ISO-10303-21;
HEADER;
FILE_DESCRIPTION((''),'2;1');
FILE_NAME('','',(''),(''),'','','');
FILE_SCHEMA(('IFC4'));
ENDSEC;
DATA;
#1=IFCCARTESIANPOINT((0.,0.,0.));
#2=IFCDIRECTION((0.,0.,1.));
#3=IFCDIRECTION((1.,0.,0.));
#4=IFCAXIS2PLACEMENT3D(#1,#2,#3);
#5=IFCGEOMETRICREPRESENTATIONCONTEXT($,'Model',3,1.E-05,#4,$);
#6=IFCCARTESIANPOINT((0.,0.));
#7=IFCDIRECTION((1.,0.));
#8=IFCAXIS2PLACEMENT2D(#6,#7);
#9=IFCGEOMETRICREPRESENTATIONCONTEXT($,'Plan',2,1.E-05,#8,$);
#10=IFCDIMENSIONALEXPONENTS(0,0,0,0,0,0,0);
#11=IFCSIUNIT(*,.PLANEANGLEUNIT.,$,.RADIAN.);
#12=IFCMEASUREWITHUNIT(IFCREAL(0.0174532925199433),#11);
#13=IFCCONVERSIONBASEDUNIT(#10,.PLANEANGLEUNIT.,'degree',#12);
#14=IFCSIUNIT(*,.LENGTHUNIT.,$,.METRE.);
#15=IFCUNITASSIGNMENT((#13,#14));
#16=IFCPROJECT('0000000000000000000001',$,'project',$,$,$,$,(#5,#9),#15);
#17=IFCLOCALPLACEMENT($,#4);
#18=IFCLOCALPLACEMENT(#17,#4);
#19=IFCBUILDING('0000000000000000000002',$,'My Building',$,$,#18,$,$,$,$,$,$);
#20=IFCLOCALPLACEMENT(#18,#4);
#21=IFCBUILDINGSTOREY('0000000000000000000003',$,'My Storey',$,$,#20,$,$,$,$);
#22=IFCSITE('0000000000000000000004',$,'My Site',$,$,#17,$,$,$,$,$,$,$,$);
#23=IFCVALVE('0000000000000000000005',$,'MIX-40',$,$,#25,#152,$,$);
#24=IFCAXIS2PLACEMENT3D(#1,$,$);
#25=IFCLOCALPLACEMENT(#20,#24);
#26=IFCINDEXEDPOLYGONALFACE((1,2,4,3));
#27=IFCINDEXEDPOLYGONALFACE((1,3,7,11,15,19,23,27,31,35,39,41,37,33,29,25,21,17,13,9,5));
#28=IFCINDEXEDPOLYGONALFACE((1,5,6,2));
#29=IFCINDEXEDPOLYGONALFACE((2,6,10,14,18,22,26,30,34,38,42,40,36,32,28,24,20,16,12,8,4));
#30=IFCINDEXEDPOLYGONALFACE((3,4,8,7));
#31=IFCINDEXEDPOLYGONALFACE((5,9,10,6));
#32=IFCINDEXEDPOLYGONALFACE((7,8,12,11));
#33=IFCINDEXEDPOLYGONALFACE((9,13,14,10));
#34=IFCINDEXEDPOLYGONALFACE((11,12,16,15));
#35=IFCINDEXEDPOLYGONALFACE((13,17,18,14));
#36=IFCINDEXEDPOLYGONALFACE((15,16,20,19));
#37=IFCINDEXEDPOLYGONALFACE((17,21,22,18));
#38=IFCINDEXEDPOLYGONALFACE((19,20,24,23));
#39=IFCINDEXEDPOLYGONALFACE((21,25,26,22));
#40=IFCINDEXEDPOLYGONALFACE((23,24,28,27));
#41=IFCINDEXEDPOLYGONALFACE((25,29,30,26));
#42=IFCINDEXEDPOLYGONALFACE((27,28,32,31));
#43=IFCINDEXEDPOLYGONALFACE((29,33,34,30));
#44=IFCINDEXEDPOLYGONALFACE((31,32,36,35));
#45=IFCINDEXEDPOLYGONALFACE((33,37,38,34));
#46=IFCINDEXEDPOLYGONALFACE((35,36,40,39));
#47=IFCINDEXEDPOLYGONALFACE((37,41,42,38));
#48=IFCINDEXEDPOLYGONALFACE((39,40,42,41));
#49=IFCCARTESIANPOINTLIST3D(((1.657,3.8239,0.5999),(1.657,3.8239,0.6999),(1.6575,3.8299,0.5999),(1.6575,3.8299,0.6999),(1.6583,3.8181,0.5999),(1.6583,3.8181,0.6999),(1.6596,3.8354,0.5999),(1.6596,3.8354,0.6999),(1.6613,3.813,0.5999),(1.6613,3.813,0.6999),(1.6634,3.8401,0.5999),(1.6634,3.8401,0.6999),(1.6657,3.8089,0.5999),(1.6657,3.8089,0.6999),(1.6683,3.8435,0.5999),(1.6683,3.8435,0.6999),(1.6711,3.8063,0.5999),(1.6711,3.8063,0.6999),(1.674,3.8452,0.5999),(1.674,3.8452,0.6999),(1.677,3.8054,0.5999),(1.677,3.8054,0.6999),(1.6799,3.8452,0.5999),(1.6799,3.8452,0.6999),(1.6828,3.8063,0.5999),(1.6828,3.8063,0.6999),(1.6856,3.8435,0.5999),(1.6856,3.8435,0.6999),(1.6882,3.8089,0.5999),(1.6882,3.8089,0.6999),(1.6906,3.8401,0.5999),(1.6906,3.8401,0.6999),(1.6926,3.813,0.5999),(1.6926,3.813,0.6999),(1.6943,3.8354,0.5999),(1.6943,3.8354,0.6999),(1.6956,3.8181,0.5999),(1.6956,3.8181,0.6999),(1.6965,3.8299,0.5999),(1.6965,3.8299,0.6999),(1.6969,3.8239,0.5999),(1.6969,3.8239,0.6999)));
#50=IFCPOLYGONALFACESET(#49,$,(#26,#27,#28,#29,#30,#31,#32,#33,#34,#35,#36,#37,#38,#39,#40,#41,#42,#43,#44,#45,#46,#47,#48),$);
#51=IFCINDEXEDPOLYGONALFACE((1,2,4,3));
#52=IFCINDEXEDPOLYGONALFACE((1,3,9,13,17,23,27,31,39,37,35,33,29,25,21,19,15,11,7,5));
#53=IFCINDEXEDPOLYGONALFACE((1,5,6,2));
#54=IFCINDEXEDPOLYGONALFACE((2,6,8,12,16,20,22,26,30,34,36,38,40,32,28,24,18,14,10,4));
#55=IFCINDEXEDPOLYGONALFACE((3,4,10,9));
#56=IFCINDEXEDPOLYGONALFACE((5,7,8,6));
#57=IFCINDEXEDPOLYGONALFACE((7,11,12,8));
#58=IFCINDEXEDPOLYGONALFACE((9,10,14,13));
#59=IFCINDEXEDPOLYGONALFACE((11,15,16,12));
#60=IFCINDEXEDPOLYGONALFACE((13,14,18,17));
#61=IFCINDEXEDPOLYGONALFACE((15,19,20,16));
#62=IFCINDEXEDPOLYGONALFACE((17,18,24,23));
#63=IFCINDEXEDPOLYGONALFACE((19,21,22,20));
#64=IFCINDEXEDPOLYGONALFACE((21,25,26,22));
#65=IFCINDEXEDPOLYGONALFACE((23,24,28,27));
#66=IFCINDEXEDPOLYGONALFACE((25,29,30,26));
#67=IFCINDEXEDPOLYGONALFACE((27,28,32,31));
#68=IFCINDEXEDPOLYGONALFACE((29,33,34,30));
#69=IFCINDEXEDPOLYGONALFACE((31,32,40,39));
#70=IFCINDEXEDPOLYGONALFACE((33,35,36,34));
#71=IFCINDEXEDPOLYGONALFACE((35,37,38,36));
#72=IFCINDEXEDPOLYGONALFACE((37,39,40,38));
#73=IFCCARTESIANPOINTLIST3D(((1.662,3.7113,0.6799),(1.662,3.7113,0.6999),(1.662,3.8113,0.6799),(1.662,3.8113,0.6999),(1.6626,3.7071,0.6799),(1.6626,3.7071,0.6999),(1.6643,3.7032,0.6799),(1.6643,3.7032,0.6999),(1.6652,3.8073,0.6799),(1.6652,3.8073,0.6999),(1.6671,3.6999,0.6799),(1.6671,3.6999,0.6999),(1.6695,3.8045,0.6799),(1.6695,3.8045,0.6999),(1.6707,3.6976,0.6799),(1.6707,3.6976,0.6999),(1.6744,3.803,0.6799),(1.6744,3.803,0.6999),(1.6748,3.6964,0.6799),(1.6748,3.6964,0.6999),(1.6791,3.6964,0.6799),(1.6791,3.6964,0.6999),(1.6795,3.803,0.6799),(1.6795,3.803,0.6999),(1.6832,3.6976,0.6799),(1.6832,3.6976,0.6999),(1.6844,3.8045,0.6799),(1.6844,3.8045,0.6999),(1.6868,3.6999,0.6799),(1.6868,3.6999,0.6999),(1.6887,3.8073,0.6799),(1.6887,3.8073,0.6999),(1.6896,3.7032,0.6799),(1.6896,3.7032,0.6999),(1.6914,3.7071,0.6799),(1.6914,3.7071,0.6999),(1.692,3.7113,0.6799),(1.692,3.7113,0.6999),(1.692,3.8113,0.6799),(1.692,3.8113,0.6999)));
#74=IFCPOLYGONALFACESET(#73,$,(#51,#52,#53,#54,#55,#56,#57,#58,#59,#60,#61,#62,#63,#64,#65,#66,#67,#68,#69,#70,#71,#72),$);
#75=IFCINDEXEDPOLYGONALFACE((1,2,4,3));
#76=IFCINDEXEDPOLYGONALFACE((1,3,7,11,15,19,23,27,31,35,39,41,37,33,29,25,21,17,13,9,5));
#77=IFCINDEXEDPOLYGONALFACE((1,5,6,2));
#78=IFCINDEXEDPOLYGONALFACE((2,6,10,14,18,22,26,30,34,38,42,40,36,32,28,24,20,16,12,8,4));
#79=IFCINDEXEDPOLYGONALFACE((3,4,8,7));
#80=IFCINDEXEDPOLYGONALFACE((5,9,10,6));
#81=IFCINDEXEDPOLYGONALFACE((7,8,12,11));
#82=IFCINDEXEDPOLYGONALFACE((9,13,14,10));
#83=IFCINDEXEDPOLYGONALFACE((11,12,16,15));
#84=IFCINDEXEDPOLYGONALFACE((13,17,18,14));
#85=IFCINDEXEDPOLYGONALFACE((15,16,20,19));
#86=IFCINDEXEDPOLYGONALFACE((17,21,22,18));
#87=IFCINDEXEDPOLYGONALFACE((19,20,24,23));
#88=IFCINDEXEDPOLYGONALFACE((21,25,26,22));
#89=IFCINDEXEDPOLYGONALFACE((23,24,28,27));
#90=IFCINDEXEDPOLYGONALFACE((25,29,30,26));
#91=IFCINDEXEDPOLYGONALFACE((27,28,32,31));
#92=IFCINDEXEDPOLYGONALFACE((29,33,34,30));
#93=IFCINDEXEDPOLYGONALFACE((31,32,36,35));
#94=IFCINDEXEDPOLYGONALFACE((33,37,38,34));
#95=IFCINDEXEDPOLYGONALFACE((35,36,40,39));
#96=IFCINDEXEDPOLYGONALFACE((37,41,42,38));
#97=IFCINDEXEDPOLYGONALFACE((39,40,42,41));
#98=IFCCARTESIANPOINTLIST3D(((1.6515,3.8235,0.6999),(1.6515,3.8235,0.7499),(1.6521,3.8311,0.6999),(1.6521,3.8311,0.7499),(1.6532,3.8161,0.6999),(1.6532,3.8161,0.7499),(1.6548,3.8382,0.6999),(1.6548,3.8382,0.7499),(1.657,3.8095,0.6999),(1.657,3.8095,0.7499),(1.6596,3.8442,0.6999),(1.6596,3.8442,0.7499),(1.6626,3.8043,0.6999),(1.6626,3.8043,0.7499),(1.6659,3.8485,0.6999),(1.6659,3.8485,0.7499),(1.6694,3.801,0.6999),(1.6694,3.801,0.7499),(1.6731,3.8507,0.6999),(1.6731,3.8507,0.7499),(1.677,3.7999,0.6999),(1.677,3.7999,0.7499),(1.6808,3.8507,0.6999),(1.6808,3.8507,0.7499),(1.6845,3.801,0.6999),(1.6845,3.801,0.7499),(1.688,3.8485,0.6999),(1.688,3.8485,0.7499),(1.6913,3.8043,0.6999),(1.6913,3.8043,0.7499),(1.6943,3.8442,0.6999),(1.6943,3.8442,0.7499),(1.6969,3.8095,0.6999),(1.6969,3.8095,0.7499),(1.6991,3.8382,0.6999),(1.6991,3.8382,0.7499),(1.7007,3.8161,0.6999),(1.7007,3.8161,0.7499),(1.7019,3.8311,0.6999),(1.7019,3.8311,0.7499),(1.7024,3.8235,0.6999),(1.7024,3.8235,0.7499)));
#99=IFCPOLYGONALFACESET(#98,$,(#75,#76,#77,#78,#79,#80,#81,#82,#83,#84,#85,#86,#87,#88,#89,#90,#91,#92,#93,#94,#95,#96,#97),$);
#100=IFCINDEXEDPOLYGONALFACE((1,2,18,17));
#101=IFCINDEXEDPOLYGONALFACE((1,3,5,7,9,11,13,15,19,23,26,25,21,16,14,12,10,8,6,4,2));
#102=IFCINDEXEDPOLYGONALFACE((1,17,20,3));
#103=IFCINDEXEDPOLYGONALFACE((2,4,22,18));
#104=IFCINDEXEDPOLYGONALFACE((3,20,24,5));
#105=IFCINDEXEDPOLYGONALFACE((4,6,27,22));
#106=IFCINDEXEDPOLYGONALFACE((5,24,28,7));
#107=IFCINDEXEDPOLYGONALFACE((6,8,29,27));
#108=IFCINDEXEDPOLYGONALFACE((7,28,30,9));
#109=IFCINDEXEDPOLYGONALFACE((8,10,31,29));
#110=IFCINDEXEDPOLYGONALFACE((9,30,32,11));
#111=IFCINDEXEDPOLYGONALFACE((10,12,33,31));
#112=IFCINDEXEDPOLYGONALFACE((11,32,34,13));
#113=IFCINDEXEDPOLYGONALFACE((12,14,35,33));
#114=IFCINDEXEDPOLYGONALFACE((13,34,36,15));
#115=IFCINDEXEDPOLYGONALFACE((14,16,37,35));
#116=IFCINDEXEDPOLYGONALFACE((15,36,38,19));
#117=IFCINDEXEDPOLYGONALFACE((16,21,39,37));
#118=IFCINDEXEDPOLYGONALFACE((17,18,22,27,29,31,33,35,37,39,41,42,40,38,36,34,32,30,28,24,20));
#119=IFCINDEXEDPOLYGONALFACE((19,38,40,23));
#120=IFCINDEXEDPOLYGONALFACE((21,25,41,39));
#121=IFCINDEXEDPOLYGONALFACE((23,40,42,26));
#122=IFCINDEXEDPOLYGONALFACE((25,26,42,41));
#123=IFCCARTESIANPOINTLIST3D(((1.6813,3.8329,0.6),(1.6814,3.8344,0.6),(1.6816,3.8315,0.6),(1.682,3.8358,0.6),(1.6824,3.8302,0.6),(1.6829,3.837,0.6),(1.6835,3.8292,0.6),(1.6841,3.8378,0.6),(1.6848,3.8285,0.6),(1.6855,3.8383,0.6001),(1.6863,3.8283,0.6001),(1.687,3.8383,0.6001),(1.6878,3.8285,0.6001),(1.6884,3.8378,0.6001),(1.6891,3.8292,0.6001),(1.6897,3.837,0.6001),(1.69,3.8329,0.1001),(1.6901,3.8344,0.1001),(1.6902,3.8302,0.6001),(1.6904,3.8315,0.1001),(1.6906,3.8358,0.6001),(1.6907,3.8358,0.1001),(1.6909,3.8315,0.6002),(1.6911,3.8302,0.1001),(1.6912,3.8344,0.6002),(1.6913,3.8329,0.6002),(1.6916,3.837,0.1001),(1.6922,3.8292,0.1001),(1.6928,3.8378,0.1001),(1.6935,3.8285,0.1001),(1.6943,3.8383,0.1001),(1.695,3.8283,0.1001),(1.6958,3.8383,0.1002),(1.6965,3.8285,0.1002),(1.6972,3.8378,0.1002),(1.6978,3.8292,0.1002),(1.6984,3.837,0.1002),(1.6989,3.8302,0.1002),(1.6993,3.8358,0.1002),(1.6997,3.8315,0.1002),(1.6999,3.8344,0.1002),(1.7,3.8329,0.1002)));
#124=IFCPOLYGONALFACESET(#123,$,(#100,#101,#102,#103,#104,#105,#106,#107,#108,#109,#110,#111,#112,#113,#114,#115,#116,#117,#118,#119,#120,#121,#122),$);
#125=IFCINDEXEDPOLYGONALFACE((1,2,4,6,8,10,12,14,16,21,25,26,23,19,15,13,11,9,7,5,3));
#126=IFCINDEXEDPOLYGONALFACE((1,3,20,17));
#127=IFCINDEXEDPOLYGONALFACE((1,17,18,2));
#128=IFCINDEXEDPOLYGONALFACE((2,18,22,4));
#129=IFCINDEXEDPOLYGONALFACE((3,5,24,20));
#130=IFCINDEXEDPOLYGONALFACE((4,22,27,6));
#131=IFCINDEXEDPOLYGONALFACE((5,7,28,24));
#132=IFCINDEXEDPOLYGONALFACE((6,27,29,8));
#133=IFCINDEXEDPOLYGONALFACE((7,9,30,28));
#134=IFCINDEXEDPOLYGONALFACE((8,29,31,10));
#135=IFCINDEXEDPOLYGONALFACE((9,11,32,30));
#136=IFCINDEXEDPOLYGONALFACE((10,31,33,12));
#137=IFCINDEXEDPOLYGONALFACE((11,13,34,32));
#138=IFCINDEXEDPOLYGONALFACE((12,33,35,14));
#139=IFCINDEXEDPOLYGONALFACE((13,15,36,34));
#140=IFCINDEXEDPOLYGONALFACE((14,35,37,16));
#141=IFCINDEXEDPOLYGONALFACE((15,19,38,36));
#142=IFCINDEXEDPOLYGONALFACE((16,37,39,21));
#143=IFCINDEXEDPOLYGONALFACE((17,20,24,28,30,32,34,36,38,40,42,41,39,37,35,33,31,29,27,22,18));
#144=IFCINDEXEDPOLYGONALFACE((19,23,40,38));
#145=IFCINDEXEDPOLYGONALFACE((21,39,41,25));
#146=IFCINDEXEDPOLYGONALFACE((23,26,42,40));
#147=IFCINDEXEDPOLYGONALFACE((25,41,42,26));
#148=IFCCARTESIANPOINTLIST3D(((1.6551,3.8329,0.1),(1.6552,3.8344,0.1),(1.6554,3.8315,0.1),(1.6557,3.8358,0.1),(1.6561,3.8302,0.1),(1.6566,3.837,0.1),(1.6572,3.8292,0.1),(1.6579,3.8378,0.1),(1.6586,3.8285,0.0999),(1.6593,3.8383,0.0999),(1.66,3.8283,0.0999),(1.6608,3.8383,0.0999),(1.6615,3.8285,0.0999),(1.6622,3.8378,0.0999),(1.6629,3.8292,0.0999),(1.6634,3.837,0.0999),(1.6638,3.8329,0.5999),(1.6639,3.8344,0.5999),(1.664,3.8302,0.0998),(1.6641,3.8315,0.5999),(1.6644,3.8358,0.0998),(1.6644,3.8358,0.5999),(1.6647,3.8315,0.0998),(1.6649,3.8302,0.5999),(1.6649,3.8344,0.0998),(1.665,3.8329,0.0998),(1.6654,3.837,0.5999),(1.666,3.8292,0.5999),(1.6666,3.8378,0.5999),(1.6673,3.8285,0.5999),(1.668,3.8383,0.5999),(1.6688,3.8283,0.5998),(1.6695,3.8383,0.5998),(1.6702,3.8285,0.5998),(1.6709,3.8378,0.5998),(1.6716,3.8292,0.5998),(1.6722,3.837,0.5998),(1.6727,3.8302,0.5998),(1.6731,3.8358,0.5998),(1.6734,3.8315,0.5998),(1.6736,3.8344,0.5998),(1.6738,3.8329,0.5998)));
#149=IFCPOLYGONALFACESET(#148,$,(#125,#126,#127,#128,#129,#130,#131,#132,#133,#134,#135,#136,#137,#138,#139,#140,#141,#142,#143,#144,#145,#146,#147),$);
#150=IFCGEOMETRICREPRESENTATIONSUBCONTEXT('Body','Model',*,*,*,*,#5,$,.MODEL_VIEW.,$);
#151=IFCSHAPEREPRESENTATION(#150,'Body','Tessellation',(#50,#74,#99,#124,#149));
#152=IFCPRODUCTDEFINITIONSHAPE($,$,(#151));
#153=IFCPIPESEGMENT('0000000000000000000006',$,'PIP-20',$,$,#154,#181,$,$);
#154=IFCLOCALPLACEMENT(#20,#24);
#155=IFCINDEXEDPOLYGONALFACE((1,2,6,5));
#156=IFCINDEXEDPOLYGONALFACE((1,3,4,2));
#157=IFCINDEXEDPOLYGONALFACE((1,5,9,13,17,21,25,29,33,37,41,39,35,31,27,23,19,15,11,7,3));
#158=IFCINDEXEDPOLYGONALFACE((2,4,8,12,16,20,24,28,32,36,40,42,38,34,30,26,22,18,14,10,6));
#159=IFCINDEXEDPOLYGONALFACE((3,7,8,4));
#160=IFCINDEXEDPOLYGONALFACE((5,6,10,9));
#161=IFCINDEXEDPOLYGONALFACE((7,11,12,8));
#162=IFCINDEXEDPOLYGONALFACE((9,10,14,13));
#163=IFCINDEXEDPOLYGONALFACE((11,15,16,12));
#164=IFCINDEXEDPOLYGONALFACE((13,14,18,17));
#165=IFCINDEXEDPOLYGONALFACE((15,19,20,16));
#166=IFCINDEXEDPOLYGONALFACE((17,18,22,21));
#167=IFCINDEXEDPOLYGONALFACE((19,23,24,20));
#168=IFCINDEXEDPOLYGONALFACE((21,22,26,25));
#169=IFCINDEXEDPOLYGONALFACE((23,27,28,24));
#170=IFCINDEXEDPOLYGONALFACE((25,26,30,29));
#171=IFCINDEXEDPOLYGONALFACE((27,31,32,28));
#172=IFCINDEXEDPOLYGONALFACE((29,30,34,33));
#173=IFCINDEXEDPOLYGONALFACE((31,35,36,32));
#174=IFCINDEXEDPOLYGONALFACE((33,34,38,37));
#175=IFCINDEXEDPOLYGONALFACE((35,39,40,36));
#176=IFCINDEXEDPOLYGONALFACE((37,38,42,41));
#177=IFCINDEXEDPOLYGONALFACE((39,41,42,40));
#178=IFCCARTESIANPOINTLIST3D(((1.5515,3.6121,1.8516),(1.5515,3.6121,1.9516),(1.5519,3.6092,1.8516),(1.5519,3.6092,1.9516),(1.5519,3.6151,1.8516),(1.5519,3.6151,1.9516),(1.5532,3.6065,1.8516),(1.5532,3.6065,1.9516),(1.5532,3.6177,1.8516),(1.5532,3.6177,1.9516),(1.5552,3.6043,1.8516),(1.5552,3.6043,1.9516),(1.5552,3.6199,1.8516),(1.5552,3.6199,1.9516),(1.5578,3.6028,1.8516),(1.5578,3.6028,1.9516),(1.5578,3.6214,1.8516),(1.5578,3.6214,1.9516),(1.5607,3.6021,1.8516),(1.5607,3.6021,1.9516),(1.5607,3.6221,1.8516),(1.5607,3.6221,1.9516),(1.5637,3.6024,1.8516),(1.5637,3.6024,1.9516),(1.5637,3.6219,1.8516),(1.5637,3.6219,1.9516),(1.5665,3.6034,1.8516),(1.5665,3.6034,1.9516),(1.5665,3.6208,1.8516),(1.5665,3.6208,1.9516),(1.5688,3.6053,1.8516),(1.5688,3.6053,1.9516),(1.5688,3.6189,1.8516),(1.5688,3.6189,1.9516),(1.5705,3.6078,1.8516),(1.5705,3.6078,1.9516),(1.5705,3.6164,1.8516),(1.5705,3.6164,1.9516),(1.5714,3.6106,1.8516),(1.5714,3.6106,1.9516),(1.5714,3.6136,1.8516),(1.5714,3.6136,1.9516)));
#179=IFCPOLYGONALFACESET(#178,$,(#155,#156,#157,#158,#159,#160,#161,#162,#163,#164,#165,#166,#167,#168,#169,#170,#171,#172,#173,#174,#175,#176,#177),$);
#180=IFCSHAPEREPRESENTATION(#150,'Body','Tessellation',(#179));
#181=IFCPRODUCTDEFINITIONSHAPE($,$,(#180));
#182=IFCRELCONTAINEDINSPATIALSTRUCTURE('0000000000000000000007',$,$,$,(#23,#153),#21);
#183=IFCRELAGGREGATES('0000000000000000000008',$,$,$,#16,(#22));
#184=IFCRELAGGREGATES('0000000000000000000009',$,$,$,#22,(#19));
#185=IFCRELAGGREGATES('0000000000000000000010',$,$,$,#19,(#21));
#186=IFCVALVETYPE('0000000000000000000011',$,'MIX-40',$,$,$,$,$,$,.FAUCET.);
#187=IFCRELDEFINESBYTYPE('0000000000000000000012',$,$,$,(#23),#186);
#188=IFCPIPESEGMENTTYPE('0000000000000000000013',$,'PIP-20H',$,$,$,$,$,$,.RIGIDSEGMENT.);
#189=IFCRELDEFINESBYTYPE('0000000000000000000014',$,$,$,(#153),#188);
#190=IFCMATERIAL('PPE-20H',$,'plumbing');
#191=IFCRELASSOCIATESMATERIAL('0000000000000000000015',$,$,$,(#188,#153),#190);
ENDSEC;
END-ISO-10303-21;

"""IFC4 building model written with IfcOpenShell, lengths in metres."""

from ifc_helpers import new_model, entity, si_unit, converted_unit, frame, frame_2d, origin_with_axes, origin_2d, origin_2d_with_axis, place, context, subcontext, project, spatial, line, arc, indexed_curve, circle_curve, circle, outline, extrude, source, transform, mapped, material, material_profile, profile_set, profile_usage, type_object, type_shapes, element, save


model = new_model("IFC4")

# Units and contexts
model_context = context("Model", 3, precision=1e-05, world=origin_with_axes())
plan_context = context("Plan", 2, precision=1e-05, world=origin_2d_with_axis())
body_context = subcontext(model_context, "Body", "Model", "MODEL_VIEW")
ifc_project = project(units=[converted_unit("PLANEANGLEUNIT", "degree", entity("IfcReal", 0.0174532925199433), si_unit("PLANEANGLEUNIT", "RADIAN"), dimensions=[0, 0, 0, 0, 0, 0, 0]), si_unit("LENGTHUNIT", "METRE")], contexts=[model_context, plan_context])

# Site, building, storey
site_placement = place(None, origin_with_axes())
site = spatial("IfcSite", under=ifc_project, at=site_placement, Name="My Site")
building_placement = place(site_placement, origin_with_axes())
building = spatial("IfcBuilding", under=site, at=building_placement, Name="My Building")
storey_placement = place(building_placement, origin_with_axes())
storey = spatial("IfcBuildingStorey", under=building, at=storey_placement, Name="My Storey")

# Valve
valve_type = type_object("IfcValveType", Name="MIX-40", PredefinedType="FAUCET")
shared_shape_1 = source(origin_with_axes(), body_context, "Body", "SweptSolid", [
    extrude(outline(circle_curve(frame_2d((0.0, 0.0)), 0.02)), frame((-0.0001, 0.0008, 0.0), z_axis=(0.0, 0.0, 1.0), x_axis=(1.0, 0.0, 0.0)), (0.0, 0.0, 1.0), 0.1),
    extrude(outline(indexed_curve([(0.0032, 0.0013), (0.0117, 0.0163), (0.0032, 0.0313), (0.1032, 0.0313), (0.1183, 0.0163), (0.1032, 0.0013)], segments=[arc(1, 2, 3), line(3, 4), arc(4, 5, 6), line(6, 1)])), frame((0.0108, -0.0156, 0.08), z_axis=(0.0, 0.0, 1.0), x_axis=(1.0, 0.0, 0.0)), (0.0, 0.0, 1.0), 0.02),
    extrude(outline(circle_curve(frame_2d((0.0, 0.0)), 0.0255)), frame((-0.0001, 0.0008, 0.1), z_axis=(0.0, 0.0, 1.0), x_axis=(1.0, 0.0, 0.0)), (0.0, 0.0, 1.0), 0.05),
    extrude(outline(circle_curve(origin_2d(), 0.005)), frame((-0.0079, 0.0188, -0.4998), z_axis=(0.0, -0.017452, 0.999848), x_axis=(1.0, 0.0, 0.0)), (0.0, 0.0, 1.0), 0.5),
    extrude(outline(circle_curve(origin_2d(), 0.005)), frame((-0.0079, -0.0162, -0.5), z_axis=(0.0, 0.017452, 0.999848), x_axis=(1.0, 0.0, 0.0)), (0.0, 0.0, 1.0), 0.5),
])
type_shapes(valve_type, [shared_shape_1])
for number, where, z_axis, x_axis, name in (
    (1, (1.6762, 3.8254, 0.5999), (0.0, 0.0, 1.0), (0.0, -1.0, 0.0), "MIX-40"),
):
    element("IfcValve", number, at=place(storey_placement, frame(where, z_axis=z_axis, x_axis=x_axis)), inside=storey, type_object=valve_type, Name=name, context=body_context, shape_type="MappedRepresentation", body=[
        mapped(shared_shape_1, transform((0.0, 0.0, 0.0), x_axis=(1.0, 0.0, 0.0), y_axis=(0.0, 1.0, 0.0), z_axis=(0.0, 0.0, 1.0), scale=1.0)),
    ])

# Pipe segment
ifc_material_1 = material(Name="PPE-20H", Category="plumbing")
ifc_material_profile_1 = material_profile(ifc_material_1, circle(Radius=0.01, kind="CURVE"))
ifc_profile_set_1 = profile_set([ifc_material_profile_1])
ifc_profile_usage_1 = profile_usage(ifc_profile_set_1, cardinal=5)
pipe_segment_type_1 = type_object("IfcPipeSegmentType", Name="PIP-20H", PredefinedType="RIGIDSEGMENT", material=ifc_profile_set_1)
pipe_segment_1_placement = place(storey_placement, frame((1.5615, 3.6121, 1.9516), z_axis=(0.0, 0.0, -1.0), x_axis=(-1.0, 0.0, 0.0)))
element("IfcPipeSegment", 2, at=pipe_segment_1_placement, inside=storey, type_object=pipe_segment_type_1, material=ifc_profile_usage_1, Name="PIP-20", context=body_context, shape_type="SweptSolid", body=[
    extrude(circle(Radius=0.01, kind="CURVE"), origin_with_axes(), (0.0, 0.0, 1.0), 0.1),
])

save(model, "model.ifc")
